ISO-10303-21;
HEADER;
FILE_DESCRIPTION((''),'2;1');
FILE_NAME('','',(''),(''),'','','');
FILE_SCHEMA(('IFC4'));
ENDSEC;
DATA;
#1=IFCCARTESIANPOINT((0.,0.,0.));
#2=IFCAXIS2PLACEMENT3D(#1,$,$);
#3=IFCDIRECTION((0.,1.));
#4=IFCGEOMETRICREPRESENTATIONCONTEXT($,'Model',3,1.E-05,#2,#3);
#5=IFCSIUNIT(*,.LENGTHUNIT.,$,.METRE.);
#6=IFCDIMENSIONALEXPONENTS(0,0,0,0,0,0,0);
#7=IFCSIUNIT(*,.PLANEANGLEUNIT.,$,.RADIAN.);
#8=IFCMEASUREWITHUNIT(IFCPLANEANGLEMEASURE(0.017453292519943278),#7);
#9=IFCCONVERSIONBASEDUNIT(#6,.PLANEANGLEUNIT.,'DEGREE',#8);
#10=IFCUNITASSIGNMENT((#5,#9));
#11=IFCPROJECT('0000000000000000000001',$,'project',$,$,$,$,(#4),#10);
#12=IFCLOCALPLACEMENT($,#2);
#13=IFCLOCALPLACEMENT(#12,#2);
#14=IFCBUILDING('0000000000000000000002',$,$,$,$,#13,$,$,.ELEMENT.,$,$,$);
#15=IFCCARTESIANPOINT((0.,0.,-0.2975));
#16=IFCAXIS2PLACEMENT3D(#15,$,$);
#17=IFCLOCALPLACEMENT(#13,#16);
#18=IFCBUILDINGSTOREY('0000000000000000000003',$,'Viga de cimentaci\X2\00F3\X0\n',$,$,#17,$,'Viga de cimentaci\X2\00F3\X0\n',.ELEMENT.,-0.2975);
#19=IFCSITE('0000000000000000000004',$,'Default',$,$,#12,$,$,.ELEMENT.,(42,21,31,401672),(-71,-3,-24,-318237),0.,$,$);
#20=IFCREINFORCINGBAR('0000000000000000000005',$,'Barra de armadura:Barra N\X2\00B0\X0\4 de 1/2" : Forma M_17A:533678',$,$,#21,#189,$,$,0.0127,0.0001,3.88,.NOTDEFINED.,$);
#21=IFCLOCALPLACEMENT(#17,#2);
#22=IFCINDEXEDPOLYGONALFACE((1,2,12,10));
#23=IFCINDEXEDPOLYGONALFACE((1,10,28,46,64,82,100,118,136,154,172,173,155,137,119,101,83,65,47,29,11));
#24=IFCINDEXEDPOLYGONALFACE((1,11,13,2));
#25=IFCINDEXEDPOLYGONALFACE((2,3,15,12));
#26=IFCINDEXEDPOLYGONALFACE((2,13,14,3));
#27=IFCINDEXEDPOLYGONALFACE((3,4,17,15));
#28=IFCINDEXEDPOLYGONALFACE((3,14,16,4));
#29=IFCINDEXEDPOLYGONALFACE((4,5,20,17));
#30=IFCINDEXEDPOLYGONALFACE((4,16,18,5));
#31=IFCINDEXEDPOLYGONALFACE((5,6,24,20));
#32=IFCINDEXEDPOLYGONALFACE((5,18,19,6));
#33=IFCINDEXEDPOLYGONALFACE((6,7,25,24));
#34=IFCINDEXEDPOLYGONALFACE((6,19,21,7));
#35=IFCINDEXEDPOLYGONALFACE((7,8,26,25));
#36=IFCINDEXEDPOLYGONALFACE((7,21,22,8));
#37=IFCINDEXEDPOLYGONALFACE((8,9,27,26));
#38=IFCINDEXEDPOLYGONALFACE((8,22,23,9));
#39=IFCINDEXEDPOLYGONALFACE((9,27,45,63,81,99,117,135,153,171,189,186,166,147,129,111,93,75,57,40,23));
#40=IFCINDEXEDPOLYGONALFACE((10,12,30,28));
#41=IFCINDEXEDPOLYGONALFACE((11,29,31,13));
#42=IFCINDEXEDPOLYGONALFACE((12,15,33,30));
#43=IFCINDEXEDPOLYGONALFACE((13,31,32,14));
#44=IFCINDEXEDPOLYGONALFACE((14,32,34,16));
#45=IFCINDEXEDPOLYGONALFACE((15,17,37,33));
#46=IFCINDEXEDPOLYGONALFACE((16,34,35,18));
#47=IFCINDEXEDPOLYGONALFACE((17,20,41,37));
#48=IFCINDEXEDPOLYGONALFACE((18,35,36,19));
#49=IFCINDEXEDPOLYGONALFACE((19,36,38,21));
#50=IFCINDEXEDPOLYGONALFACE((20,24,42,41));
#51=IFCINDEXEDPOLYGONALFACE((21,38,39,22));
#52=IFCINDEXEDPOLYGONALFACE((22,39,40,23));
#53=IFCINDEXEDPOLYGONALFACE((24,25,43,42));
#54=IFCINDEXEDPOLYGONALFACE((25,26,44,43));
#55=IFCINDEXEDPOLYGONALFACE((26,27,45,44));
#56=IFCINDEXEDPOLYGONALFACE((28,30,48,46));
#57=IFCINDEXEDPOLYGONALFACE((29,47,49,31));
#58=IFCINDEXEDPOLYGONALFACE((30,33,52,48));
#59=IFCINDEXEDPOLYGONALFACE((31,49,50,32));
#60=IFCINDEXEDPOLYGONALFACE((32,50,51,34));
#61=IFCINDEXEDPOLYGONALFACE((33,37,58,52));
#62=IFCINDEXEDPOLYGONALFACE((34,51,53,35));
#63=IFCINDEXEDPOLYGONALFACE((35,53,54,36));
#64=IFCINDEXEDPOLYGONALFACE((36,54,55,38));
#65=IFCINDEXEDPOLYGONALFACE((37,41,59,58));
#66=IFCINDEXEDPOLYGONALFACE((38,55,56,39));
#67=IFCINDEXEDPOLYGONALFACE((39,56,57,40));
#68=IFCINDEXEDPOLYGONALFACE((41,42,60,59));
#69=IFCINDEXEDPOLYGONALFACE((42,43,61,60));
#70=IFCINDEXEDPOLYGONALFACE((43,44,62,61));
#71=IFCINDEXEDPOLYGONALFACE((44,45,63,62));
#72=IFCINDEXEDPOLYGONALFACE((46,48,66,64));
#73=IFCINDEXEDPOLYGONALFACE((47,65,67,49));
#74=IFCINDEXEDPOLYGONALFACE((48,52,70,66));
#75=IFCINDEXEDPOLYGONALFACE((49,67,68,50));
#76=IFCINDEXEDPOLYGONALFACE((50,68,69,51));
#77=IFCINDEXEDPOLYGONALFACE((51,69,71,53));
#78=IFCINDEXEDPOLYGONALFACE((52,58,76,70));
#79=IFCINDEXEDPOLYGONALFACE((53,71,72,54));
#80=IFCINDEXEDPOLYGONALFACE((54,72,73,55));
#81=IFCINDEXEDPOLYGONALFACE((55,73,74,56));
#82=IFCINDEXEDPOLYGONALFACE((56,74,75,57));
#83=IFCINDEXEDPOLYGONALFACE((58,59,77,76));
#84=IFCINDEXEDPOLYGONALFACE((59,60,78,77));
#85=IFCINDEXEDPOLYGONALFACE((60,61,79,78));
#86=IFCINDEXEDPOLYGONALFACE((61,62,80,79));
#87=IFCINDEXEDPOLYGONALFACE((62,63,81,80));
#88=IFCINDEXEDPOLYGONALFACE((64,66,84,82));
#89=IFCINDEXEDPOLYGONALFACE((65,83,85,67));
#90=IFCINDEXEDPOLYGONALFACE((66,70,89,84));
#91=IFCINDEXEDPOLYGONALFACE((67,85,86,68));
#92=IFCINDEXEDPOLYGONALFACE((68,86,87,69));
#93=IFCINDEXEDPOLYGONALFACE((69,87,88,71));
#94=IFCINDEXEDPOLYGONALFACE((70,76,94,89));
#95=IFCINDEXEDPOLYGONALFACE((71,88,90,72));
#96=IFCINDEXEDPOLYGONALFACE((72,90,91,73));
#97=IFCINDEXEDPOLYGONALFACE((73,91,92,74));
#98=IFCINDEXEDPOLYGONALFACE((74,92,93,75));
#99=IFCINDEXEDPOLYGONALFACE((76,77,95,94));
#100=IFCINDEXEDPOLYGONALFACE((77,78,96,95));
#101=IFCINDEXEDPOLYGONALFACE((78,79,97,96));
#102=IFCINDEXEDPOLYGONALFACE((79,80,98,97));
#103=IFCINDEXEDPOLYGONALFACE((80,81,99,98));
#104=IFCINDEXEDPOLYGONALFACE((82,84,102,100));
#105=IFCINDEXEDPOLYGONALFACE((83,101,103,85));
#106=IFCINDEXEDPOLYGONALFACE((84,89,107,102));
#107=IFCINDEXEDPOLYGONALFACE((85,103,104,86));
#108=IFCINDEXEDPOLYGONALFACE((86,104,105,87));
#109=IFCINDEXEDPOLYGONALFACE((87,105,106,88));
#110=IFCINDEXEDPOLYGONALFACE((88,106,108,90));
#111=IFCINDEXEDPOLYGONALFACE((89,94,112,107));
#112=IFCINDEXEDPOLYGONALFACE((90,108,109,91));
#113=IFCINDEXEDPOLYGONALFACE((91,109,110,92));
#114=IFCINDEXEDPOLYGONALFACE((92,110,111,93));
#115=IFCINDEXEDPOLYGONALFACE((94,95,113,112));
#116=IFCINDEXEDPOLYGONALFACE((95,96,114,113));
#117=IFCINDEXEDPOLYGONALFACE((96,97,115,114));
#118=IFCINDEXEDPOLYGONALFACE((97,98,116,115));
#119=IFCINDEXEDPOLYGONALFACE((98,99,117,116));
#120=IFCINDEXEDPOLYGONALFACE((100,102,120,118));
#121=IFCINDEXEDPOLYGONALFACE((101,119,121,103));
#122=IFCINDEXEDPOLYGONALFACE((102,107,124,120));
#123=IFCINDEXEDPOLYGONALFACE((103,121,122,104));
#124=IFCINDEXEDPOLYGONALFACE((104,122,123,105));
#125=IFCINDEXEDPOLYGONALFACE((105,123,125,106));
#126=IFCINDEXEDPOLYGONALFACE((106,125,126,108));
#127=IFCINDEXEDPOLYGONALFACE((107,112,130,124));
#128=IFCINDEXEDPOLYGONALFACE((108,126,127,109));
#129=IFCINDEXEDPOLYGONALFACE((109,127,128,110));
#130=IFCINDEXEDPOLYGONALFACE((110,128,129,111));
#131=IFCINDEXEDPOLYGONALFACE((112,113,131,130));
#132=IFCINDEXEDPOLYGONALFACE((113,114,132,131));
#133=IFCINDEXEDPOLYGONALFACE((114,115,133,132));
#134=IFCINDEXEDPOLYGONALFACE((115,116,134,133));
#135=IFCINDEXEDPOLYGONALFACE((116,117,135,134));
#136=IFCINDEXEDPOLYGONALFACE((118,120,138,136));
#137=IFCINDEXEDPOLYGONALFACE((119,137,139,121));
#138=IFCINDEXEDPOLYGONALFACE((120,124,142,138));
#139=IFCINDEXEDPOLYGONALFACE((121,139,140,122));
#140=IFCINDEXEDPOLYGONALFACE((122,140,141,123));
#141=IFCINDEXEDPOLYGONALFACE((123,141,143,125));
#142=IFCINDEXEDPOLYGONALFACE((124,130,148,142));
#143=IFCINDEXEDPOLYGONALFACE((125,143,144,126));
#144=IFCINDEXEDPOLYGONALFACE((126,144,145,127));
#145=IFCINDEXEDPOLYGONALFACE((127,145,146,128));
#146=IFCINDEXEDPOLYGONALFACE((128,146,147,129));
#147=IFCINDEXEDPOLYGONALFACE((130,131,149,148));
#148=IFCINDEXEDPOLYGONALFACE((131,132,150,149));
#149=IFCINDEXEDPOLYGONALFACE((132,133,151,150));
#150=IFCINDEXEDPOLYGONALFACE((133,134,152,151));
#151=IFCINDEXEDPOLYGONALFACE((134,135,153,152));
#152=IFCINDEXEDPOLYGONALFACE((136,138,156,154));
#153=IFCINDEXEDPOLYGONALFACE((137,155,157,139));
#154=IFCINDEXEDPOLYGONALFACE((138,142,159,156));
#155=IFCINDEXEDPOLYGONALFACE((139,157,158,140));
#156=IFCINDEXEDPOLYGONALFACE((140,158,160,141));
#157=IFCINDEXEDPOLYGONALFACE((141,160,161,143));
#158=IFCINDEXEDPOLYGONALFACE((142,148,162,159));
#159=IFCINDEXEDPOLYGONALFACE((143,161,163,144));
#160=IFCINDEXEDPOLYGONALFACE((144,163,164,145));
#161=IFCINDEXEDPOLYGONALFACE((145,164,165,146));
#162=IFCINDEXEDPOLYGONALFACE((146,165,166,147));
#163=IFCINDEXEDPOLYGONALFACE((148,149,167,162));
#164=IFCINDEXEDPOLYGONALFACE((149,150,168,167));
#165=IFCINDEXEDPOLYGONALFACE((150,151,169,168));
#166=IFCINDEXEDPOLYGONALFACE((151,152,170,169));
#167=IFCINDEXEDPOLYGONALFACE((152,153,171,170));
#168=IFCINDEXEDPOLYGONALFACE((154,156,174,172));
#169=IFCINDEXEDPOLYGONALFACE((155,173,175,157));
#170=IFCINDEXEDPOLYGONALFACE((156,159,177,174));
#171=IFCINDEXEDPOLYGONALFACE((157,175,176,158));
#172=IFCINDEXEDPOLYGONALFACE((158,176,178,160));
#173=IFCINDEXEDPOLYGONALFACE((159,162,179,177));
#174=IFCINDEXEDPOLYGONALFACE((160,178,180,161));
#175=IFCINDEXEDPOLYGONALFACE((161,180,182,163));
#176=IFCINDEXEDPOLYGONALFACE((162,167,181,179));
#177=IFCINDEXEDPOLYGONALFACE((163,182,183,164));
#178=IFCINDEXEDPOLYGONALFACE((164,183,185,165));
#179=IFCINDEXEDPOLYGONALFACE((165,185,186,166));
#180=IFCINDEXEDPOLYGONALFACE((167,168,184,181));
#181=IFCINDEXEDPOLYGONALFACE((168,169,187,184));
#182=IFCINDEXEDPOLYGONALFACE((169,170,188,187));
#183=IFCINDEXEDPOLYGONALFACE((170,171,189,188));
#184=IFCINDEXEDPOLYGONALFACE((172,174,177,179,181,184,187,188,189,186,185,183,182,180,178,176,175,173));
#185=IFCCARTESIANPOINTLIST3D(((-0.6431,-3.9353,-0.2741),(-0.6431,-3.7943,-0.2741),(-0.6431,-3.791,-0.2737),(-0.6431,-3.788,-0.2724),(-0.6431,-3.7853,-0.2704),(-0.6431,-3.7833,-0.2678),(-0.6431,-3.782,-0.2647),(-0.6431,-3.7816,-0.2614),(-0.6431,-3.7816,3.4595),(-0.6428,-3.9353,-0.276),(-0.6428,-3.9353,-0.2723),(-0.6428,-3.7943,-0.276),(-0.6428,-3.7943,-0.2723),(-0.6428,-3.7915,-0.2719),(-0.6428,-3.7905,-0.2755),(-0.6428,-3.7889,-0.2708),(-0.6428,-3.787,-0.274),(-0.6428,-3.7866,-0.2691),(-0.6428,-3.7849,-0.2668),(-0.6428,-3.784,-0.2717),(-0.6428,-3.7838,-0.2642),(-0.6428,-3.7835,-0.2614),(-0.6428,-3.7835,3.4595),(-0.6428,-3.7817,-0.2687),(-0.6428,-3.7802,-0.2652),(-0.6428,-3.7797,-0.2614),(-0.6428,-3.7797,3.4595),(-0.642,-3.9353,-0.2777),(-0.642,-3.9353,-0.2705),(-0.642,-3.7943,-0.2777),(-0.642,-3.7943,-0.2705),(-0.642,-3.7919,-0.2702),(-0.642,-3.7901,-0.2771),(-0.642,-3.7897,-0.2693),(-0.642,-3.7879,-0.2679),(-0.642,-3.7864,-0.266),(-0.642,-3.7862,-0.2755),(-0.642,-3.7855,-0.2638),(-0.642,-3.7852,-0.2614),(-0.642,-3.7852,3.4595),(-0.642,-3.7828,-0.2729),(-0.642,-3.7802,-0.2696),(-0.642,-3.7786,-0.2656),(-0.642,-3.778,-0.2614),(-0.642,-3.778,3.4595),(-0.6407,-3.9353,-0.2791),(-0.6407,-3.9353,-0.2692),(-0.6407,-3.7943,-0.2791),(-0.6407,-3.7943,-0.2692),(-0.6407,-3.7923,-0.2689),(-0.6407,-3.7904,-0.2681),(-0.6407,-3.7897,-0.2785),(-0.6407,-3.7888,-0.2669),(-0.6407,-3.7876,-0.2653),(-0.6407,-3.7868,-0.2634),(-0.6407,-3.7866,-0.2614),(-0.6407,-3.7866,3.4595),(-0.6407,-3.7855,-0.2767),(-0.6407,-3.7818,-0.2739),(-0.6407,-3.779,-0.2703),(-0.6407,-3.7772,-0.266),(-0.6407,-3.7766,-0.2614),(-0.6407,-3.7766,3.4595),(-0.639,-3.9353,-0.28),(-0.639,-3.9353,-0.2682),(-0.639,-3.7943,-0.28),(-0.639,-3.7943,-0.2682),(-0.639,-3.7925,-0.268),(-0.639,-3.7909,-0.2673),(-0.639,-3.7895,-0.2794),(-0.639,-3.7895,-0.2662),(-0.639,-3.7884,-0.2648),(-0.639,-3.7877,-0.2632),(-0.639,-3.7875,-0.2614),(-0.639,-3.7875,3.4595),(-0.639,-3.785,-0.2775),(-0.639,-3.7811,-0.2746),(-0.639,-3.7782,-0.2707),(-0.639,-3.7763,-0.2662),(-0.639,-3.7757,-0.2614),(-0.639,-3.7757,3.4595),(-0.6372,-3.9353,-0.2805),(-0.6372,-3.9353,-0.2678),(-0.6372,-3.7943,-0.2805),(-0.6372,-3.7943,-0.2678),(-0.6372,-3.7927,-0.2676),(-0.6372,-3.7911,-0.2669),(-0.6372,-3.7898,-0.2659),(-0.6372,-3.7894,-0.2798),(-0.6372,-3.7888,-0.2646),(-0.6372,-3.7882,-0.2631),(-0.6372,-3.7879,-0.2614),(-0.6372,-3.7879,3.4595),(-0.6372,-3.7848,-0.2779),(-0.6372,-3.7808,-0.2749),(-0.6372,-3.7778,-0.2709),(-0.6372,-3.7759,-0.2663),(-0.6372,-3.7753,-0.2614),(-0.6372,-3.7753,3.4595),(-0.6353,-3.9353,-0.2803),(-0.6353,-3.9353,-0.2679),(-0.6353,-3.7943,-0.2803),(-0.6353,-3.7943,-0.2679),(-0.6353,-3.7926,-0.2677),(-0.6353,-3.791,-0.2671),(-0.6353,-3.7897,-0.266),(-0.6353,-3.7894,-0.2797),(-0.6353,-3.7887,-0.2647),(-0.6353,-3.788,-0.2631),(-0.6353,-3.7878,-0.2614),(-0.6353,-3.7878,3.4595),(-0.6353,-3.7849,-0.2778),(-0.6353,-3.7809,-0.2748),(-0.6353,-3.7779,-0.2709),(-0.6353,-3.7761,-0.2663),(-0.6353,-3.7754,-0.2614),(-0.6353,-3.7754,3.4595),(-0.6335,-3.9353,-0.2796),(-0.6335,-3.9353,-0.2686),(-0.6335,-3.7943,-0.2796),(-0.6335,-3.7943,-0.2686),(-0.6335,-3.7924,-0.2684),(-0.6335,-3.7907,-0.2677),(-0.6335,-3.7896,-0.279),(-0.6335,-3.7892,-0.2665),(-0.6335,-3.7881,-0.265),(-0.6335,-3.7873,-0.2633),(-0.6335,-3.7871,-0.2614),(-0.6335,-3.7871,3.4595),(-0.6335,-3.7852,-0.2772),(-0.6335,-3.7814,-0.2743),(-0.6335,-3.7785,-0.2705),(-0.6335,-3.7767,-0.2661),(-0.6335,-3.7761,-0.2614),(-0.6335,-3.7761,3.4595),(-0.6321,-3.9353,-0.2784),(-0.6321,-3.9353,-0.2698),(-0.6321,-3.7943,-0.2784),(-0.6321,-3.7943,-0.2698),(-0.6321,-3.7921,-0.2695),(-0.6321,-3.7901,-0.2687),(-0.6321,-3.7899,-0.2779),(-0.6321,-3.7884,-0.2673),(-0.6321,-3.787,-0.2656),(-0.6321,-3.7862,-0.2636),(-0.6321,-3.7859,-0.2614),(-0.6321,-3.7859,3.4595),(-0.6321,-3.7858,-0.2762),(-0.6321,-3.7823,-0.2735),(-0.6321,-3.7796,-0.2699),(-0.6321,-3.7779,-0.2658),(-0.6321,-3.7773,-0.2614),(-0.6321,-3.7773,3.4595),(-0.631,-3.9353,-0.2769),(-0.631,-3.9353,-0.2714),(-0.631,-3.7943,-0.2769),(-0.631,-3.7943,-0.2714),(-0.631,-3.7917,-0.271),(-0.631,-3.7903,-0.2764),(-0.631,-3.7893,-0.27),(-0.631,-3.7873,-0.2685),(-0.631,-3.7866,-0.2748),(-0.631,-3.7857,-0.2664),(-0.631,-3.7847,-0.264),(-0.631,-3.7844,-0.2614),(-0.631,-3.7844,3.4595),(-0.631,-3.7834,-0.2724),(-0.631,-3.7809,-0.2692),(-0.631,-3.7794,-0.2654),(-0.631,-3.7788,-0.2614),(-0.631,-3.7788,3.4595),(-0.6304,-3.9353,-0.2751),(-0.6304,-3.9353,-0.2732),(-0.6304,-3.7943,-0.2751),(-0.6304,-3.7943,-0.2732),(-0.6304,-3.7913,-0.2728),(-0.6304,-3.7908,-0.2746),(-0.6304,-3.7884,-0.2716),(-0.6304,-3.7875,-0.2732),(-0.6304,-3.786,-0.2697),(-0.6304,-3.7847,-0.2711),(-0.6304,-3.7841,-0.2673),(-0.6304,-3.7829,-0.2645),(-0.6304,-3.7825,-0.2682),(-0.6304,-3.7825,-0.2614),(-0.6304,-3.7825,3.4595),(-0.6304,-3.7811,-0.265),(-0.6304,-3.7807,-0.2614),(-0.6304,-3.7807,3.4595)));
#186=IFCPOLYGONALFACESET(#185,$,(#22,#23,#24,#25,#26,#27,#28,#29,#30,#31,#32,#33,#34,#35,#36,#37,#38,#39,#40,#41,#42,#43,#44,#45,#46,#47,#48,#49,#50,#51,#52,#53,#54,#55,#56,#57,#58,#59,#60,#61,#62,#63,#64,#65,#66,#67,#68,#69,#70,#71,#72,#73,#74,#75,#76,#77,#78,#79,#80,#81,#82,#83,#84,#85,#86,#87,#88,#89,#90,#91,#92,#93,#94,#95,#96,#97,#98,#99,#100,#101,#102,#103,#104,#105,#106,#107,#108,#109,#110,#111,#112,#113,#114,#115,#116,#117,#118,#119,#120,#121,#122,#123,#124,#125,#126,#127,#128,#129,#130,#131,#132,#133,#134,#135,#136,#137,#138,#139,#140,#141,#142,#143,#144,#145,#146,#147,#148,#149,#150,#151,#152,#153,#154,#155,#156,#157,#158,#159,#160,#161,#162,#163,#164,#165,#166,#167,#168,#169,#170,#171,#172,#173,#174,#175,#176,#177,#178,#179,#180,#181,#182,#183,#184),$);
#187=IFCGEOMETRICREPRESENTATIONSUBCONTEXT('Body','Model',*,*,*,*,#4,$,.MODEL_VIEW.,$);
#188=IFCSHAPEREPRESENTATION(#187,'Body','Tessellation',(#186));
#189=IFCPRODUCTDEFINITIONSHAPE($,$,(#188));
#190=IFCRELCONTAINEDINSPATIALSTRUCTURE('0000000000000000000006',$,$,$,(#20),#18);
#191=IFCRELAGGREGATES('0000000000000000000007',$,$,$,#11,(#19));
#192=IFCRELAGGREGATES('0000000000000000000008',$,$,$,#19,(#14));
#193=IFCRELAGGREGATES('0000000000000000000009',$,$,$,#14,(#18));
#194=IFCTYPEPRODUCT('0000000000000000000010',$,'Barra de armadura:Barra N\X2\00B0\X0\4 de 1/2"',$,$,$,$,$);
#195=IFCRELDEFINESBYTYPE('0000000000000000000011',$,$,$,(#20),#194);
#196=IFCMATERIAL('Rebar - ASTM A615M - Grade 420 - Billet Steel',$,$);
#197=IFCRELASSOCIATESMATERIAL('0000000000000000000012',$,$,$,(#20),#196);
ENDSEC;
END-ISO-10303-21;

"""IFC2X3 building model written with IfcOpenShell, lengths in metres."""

from ifc_helpers import new_model, entity, si_unit, converted_unit, direction, frame, origin, place, context, subcontext, project, spatial, material, type_object, element, save


model = new_model("IFC2X3")

# Units and contexts
model_context = context("Model", 3, precision=1e-05, world=origin(), true_north=direction((0.0, 1.0)))
body_context = subcontext(model_context, "Body", "Model", "MODEL_VIEW")
ifc_project = project(units=[si_unit("LENGTHUNIT", "METRE"), converted_unit("PLANEANGLEUNIT", "DEGREE", entity("IfcPlaneAngleMeasure", 0.017453292519943278), si_unit("PLANEANGLEUNIT", "RADIAN"), dimensions=[0, 0, 0, 0, 0, 0, 0])], contexts=[model_context])

# Site, building, storey
site_placement = place(None, origin())
site = spatial("IfcSite", under=ifc_project, at=site_placement, Name="Default", CompositionType="ELEMENT", RefLatitude=(42, 21, 31, 401672), RefLongitude=(-71, -3, -24, -318237), RefElevation=0.0)
building_placement = place(site_placement, origin())
building = spatial("IfcBuilding", under=site, at=building_placement, CompositionType="ELEMENT")
storey_placement = place(building_placement, frame((0.0, 0.0, -0.2975)))
storey = spatial("IfcBuildingStorey", under=building, at=storey_placement, Name="Viga de cimentación", LongName="Viga de cimentación", CompositionType="ELEMENT", Elevation=-0.2975)

# Reinforcing bar
ifc_material = material(Name="Rebar - ASTM A615M - Grade 420 - Billet Steel")
type_product_1 = type_object("IfcTypeProduct", Name="Barra de armadura:Barra N°4 de 1/2\"")
reinforcing_bar_1_placement = place(storey_placement, origin())
element("IfcReinforcingBar", 1, at=reinforcing_bar_1_placement, inside=storey, type_object=type_product_1, material=ifc_material, Name="Barra de armadura:Barra N°4 de 1/2\" : Forma M_17A:533678", BarLength=3.88, BarRole="NOTDEFINED", CrossSectionArea=0.0001, NominalDiameter=0.0127, context=body_context, shape_type="AdvancedSweptSolid", body=[
    entity("IfcSweptDiskSolid", entity("IfcCompositeCurve", [entity("IfcCompositeCurveSegment", "CONTINUOUS", True, entity("IfcPolyline", [entity("IfcCartesianPoint", [-0.6367, -3.7816, 3.4595]), entity("IfcCartesianPoint", [-0.6367, -3.7816, -0.2614])])), entity("IfcCompositeCurveSegment", "CONTINUOUS", True, entity("IfcTrimmedCurve", entity("IfcCircle", entity("IfcAxis2Placement3D", entity("IfcCartesianPoint", [-0.6367, -3.7943, -0.2614]), entity("IfcDirection", [-1.0, 0.0, 0.0]), entity("IfcDirection", [0.0, 0.0, -1.0])), 0.0127), [entity("IfcParameterValue", 270.0)], [entity("IfcParameterValue", 360.0)], True, "PARAMETER")), entity("IfcCompositeCurveSegment", "CONTINUOUS", True, entity("IfcPolyline", [entity("IfcCartesianPoint", [-0.6367, -3.7943, -0.2741]), entity("IfcCartesianPoint", [-0.6367, -3.9353, -0.2741])]))], False), 0.0063, None, 0.0, 92.0),
])

save(model, "model.ifc")
